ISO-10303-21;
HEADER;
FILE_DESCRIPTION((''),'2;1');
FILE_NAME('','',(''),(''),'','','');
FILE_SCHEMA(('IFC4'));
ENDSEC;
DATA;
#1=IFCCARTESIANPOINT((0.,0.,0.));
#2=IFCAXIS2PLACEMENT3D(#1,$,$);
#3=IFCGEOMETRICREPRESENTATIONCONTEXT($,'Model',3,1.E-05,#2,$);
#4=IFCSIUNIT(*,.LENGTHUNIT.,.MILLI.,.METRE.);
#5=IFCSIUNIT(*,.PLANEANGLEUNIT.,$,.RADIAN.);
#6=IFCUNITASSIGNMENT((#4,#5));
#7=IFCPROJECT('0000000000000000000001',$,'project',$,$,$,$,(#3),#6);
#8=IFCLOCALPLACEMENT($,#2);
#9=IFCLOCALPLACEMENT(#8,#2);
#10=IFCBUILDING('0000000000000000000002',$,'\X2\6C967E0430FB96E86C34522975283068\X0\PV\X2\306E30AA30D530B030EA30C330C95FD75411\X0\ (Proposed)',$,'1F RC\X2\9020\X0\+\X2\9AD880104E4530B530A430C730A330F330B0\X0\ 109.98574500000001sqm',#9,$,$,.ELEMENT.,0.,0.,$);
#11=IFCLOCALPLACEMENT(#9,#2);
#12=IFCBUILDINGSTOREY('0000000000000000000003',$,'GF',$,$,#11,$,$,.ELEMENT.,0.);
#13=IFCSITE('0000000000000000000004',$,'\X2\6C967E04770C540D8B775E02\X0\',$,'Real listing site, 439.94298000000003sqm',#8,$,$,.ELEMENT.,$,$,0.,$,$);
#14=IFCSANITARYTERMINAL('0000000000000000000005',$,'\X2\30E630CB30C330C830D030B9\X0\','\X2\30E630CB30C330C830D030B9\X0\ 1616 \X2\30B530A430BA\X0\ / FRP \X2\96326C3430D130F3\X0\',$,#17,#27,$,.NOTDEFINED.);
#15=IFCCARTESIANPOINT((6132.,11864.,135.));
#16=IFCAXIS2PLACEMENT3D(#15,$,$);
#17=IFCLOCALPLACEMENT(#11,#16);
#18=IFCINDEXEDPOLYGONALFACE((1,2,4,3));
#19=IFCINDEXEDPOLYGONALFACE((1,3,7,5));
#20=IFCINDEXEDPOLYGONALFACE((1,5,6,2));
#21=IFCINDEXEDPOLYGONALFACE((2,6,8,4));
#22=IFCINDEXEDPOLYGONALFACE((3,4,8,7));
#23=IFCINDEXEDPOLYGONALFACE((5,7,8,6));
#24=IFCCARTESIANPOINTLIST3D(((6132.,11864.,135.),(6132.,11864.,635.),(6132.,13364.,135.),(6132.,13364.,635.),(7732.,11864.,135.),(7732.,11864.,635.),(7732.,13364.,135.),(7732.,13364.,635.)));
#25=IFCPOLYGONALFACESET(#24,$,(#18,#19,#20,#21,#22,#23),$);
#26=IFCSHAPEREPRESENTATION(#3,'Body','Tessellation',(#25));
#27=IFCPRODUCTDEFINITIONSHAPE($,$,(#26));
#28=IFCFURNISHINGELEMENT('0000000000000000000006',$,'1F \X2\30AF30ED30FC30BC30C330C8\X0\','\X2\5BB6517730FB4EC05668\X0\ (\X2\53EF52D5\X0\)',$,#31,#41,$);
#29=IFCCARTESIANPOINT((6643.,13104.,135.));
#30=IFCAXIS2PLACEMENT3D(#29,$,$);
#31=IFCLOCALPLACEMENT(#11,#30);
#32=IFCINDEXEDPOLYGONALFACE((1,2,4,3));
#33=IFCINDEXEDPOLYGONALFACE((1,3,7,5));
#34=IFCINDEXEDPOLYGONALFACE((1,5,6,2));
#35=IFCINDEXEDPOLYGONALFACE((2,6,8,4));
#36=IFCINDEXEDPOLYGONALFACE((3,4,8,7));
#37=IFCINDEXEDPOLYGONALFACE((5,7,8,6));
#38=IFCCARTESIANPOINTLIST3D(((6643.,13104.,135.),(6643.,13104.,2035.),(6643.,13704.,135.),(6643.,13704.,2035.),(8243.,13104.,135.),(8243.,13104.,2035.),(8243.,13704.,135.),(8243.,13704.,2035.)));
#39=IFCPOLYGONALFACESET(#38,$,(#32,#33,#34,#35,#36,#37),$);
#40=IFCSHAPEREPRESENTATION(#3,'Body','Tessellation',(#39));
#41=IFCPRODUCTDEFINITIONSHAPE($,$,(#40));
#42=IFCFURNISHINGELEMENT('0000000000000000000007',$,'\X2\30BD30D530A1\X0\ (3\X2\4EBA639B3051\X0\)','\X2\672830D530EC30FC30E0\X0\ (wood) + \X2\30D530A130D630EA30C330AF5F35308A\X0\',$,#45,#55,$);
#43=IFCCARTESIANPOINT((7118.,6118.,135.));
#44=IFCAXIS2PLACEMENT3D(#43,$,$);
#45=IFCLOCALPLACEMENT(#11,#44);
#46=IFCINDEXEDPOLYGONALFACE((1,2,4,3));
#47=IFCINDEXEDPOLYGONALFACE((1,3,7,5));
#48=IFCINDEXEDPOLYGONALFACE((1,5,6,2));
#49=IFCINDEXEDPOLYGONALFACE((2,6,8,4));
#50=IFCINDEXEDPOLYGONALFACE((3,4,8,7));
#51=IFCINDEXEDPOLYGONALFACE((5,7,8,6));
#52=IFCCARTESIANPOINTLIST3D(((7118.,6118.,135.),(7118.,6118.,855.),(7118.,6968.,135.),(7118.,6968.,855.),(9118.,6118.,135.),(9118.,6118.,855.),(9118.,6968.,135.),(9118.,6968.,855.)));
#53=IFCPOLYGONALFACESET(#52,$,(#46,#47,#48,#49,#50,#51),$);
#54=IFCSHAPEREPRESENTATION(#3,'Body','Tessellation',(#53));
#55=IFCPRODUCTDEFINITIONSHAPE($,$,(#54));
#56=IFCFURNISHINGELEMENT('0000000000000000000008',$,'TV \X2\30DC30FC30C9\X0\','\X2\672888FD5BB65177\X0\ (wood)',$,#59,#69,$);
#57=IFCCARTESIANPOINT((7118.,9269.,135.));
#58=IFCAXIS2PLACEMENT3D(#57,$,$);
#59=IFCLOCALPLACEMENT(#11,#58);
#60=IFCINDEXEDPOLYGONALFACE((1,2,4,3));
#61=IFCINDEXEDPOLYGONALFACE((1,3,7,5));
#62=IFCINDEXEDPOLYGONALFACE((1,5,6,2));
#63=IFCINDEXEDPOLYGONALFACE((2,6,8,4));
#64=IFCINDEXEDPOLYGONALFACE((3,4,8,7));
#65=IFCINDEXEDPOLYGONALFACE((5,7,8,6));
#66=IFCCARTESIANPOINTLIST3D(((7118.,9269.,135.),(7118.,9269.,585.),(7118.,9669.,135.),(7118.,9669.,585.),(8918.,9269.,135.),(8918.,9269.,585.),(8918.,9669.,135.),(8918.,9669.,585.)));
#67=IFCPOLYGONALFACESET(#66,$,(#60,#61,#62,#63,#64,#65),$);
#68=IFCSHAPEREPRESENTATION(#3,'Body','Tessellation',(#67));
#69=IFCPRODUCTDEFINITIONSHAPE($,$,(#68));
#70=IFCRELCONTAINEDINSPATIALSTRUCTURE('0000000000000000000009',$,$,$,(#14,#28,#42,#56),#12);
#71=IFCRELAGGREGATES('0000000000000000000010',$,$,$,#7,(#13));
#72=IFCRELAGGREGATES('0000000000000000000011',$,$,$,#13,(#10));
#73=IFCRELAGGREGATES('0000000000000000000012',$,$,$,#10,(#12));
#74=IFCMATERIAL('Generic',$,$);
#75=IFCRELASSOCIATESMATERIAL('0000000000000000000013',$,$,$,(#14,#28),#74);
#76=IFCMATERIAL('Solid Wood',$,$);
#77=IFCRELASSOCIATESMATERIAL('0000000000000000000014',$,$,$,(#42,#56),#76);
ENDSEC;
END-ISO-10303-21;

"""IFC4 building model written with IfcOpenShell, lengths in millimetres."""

from ifc_helpers import new_model, si_unit, frame, frame_2d, origin, place, context, project, spatial, rectangle, extrude, material, element, save


model = new_model("IFC4")

# Units and contexts
model_context = context("Model", 3, precision=1e-05, world=origin())
ifc_project = project(units=[si_unit("LENGTHUNIT", "METRE", prefix="MILLI"), si_unit("PLANEANGLEUNIT", "RADIAN")], contexts=[model_context])

# Site, building, storey
site_placement = place(None, origin())
site = spatial("IfcSite", under=ifc_project, at=site_placement, Name="沖縄県名護市", ObjectType="Real listing site, 439.94298000000003sqm", CompositionType="ELEMENT", RefElevation=0.0)
building_placement = place(site_placement, origin())
building = spatial("IfcBuilding", under=site, at=building_placement, Name="沖縄・雨水利用とPVのオフグリッド志向 (Proposed)", ObjectType="1F RC造+高耐久サイディング 109.98574500000001sqm", CompositionType="ELEMENT", ElevationOfRefHeight=0.0, ElevationOfTerrain=0.0)
storey_placement = place(building_placement, origin())
storey = spatial("IfcBuildingStorey", under=building, at=storey_placement, Name="GF", CompositionType="ELEMENT", Elevation=0.0)

# Shared definitions
ifc_material_1 = material(Name="Solid Wood")

# Shared definitions
ifc_material_2 = material(Name="Generic")

# Sanitary terminal
sanitary_terminal_placement = place(storey_placement, frame((6132.0, 11864.0, 135.0)))
element("IfcSanitaryTerminal", 1, at=sanitary_terminal_placement, inside=storey, material=ifc_material_2, Name="ユニットバス", Description="ユニットバス 1616 サイズ / FRP 防水パン", PredefinedType="NOTDEFINED", context=model_context, shape_type="SweptSolid", body=[
    extrude(rectangle(XDim=1600.0, YDim=1500.0, at=frame_2d((800.0, 750.0))), frame((6132.0, 11864.0, 135.0)), (0.0, 0.0, 1.0), 500.0),
])

# Furnishing elements
furnishing_1_placement = place(storey_placement, frame((6643.0, 13104.0, 135.0)))
element("IfcFurnishingElement", 2, at=furnishing_1_placement, inside=storey, material=ifc_material_2, Name="1F クローゼット", Description="家具・什器 (可動)", context=model_context, shape_type="SweptSolid", body=[
    extrude(rectangle(XDim=1600.0, YDim=600.0, at=frame_2d((800.0, 300.0))), frame((6643.0, 13104.0, 135.0)), (0.0, 0.0, 1.0), 1900.0),
])
furnishing_2_placement = place(storey_placement, frame((7118.0, 6118.0, 135.0)))
element("IfcFurnishingElement", 3, at=furnishing_2_placement, inside=storey, material=ifc_material_1, Name="ソファ (3人掛け)", Description="木フレーム (wood) + ファブリック張り", context=model_context, shape_type="SweptSolid", body=[
    extrude(rectangle(XDim=2000.0, YDim=850.0, at=frame_2d((1000.0, 425.0))), frame((7118.0, 6118.0, 135.0)), (0.0, 0.0, 1.0), 720.0),
])
furnishing_3_placement = place(storey_placement, frame((7118.0, 9269.0, 135.0)))
element("IfcFurnishingElement", 4, at=furnishing_3_placement, inside=storey, material=ifc_material_1, Name="TV ボード", Description="木製家具 (wood)", context=model_context, shape_type="SweptSolid", body=[
    extrude(rectangle(XDim=1800.0, YDim=400.0, at=frame_2d((900.0, 200.0))), frame((7118.0, 9269.0, 135.0)), (0.0, 0.0, 1.0), 450.0),
])

save(model, "model.ifc")
